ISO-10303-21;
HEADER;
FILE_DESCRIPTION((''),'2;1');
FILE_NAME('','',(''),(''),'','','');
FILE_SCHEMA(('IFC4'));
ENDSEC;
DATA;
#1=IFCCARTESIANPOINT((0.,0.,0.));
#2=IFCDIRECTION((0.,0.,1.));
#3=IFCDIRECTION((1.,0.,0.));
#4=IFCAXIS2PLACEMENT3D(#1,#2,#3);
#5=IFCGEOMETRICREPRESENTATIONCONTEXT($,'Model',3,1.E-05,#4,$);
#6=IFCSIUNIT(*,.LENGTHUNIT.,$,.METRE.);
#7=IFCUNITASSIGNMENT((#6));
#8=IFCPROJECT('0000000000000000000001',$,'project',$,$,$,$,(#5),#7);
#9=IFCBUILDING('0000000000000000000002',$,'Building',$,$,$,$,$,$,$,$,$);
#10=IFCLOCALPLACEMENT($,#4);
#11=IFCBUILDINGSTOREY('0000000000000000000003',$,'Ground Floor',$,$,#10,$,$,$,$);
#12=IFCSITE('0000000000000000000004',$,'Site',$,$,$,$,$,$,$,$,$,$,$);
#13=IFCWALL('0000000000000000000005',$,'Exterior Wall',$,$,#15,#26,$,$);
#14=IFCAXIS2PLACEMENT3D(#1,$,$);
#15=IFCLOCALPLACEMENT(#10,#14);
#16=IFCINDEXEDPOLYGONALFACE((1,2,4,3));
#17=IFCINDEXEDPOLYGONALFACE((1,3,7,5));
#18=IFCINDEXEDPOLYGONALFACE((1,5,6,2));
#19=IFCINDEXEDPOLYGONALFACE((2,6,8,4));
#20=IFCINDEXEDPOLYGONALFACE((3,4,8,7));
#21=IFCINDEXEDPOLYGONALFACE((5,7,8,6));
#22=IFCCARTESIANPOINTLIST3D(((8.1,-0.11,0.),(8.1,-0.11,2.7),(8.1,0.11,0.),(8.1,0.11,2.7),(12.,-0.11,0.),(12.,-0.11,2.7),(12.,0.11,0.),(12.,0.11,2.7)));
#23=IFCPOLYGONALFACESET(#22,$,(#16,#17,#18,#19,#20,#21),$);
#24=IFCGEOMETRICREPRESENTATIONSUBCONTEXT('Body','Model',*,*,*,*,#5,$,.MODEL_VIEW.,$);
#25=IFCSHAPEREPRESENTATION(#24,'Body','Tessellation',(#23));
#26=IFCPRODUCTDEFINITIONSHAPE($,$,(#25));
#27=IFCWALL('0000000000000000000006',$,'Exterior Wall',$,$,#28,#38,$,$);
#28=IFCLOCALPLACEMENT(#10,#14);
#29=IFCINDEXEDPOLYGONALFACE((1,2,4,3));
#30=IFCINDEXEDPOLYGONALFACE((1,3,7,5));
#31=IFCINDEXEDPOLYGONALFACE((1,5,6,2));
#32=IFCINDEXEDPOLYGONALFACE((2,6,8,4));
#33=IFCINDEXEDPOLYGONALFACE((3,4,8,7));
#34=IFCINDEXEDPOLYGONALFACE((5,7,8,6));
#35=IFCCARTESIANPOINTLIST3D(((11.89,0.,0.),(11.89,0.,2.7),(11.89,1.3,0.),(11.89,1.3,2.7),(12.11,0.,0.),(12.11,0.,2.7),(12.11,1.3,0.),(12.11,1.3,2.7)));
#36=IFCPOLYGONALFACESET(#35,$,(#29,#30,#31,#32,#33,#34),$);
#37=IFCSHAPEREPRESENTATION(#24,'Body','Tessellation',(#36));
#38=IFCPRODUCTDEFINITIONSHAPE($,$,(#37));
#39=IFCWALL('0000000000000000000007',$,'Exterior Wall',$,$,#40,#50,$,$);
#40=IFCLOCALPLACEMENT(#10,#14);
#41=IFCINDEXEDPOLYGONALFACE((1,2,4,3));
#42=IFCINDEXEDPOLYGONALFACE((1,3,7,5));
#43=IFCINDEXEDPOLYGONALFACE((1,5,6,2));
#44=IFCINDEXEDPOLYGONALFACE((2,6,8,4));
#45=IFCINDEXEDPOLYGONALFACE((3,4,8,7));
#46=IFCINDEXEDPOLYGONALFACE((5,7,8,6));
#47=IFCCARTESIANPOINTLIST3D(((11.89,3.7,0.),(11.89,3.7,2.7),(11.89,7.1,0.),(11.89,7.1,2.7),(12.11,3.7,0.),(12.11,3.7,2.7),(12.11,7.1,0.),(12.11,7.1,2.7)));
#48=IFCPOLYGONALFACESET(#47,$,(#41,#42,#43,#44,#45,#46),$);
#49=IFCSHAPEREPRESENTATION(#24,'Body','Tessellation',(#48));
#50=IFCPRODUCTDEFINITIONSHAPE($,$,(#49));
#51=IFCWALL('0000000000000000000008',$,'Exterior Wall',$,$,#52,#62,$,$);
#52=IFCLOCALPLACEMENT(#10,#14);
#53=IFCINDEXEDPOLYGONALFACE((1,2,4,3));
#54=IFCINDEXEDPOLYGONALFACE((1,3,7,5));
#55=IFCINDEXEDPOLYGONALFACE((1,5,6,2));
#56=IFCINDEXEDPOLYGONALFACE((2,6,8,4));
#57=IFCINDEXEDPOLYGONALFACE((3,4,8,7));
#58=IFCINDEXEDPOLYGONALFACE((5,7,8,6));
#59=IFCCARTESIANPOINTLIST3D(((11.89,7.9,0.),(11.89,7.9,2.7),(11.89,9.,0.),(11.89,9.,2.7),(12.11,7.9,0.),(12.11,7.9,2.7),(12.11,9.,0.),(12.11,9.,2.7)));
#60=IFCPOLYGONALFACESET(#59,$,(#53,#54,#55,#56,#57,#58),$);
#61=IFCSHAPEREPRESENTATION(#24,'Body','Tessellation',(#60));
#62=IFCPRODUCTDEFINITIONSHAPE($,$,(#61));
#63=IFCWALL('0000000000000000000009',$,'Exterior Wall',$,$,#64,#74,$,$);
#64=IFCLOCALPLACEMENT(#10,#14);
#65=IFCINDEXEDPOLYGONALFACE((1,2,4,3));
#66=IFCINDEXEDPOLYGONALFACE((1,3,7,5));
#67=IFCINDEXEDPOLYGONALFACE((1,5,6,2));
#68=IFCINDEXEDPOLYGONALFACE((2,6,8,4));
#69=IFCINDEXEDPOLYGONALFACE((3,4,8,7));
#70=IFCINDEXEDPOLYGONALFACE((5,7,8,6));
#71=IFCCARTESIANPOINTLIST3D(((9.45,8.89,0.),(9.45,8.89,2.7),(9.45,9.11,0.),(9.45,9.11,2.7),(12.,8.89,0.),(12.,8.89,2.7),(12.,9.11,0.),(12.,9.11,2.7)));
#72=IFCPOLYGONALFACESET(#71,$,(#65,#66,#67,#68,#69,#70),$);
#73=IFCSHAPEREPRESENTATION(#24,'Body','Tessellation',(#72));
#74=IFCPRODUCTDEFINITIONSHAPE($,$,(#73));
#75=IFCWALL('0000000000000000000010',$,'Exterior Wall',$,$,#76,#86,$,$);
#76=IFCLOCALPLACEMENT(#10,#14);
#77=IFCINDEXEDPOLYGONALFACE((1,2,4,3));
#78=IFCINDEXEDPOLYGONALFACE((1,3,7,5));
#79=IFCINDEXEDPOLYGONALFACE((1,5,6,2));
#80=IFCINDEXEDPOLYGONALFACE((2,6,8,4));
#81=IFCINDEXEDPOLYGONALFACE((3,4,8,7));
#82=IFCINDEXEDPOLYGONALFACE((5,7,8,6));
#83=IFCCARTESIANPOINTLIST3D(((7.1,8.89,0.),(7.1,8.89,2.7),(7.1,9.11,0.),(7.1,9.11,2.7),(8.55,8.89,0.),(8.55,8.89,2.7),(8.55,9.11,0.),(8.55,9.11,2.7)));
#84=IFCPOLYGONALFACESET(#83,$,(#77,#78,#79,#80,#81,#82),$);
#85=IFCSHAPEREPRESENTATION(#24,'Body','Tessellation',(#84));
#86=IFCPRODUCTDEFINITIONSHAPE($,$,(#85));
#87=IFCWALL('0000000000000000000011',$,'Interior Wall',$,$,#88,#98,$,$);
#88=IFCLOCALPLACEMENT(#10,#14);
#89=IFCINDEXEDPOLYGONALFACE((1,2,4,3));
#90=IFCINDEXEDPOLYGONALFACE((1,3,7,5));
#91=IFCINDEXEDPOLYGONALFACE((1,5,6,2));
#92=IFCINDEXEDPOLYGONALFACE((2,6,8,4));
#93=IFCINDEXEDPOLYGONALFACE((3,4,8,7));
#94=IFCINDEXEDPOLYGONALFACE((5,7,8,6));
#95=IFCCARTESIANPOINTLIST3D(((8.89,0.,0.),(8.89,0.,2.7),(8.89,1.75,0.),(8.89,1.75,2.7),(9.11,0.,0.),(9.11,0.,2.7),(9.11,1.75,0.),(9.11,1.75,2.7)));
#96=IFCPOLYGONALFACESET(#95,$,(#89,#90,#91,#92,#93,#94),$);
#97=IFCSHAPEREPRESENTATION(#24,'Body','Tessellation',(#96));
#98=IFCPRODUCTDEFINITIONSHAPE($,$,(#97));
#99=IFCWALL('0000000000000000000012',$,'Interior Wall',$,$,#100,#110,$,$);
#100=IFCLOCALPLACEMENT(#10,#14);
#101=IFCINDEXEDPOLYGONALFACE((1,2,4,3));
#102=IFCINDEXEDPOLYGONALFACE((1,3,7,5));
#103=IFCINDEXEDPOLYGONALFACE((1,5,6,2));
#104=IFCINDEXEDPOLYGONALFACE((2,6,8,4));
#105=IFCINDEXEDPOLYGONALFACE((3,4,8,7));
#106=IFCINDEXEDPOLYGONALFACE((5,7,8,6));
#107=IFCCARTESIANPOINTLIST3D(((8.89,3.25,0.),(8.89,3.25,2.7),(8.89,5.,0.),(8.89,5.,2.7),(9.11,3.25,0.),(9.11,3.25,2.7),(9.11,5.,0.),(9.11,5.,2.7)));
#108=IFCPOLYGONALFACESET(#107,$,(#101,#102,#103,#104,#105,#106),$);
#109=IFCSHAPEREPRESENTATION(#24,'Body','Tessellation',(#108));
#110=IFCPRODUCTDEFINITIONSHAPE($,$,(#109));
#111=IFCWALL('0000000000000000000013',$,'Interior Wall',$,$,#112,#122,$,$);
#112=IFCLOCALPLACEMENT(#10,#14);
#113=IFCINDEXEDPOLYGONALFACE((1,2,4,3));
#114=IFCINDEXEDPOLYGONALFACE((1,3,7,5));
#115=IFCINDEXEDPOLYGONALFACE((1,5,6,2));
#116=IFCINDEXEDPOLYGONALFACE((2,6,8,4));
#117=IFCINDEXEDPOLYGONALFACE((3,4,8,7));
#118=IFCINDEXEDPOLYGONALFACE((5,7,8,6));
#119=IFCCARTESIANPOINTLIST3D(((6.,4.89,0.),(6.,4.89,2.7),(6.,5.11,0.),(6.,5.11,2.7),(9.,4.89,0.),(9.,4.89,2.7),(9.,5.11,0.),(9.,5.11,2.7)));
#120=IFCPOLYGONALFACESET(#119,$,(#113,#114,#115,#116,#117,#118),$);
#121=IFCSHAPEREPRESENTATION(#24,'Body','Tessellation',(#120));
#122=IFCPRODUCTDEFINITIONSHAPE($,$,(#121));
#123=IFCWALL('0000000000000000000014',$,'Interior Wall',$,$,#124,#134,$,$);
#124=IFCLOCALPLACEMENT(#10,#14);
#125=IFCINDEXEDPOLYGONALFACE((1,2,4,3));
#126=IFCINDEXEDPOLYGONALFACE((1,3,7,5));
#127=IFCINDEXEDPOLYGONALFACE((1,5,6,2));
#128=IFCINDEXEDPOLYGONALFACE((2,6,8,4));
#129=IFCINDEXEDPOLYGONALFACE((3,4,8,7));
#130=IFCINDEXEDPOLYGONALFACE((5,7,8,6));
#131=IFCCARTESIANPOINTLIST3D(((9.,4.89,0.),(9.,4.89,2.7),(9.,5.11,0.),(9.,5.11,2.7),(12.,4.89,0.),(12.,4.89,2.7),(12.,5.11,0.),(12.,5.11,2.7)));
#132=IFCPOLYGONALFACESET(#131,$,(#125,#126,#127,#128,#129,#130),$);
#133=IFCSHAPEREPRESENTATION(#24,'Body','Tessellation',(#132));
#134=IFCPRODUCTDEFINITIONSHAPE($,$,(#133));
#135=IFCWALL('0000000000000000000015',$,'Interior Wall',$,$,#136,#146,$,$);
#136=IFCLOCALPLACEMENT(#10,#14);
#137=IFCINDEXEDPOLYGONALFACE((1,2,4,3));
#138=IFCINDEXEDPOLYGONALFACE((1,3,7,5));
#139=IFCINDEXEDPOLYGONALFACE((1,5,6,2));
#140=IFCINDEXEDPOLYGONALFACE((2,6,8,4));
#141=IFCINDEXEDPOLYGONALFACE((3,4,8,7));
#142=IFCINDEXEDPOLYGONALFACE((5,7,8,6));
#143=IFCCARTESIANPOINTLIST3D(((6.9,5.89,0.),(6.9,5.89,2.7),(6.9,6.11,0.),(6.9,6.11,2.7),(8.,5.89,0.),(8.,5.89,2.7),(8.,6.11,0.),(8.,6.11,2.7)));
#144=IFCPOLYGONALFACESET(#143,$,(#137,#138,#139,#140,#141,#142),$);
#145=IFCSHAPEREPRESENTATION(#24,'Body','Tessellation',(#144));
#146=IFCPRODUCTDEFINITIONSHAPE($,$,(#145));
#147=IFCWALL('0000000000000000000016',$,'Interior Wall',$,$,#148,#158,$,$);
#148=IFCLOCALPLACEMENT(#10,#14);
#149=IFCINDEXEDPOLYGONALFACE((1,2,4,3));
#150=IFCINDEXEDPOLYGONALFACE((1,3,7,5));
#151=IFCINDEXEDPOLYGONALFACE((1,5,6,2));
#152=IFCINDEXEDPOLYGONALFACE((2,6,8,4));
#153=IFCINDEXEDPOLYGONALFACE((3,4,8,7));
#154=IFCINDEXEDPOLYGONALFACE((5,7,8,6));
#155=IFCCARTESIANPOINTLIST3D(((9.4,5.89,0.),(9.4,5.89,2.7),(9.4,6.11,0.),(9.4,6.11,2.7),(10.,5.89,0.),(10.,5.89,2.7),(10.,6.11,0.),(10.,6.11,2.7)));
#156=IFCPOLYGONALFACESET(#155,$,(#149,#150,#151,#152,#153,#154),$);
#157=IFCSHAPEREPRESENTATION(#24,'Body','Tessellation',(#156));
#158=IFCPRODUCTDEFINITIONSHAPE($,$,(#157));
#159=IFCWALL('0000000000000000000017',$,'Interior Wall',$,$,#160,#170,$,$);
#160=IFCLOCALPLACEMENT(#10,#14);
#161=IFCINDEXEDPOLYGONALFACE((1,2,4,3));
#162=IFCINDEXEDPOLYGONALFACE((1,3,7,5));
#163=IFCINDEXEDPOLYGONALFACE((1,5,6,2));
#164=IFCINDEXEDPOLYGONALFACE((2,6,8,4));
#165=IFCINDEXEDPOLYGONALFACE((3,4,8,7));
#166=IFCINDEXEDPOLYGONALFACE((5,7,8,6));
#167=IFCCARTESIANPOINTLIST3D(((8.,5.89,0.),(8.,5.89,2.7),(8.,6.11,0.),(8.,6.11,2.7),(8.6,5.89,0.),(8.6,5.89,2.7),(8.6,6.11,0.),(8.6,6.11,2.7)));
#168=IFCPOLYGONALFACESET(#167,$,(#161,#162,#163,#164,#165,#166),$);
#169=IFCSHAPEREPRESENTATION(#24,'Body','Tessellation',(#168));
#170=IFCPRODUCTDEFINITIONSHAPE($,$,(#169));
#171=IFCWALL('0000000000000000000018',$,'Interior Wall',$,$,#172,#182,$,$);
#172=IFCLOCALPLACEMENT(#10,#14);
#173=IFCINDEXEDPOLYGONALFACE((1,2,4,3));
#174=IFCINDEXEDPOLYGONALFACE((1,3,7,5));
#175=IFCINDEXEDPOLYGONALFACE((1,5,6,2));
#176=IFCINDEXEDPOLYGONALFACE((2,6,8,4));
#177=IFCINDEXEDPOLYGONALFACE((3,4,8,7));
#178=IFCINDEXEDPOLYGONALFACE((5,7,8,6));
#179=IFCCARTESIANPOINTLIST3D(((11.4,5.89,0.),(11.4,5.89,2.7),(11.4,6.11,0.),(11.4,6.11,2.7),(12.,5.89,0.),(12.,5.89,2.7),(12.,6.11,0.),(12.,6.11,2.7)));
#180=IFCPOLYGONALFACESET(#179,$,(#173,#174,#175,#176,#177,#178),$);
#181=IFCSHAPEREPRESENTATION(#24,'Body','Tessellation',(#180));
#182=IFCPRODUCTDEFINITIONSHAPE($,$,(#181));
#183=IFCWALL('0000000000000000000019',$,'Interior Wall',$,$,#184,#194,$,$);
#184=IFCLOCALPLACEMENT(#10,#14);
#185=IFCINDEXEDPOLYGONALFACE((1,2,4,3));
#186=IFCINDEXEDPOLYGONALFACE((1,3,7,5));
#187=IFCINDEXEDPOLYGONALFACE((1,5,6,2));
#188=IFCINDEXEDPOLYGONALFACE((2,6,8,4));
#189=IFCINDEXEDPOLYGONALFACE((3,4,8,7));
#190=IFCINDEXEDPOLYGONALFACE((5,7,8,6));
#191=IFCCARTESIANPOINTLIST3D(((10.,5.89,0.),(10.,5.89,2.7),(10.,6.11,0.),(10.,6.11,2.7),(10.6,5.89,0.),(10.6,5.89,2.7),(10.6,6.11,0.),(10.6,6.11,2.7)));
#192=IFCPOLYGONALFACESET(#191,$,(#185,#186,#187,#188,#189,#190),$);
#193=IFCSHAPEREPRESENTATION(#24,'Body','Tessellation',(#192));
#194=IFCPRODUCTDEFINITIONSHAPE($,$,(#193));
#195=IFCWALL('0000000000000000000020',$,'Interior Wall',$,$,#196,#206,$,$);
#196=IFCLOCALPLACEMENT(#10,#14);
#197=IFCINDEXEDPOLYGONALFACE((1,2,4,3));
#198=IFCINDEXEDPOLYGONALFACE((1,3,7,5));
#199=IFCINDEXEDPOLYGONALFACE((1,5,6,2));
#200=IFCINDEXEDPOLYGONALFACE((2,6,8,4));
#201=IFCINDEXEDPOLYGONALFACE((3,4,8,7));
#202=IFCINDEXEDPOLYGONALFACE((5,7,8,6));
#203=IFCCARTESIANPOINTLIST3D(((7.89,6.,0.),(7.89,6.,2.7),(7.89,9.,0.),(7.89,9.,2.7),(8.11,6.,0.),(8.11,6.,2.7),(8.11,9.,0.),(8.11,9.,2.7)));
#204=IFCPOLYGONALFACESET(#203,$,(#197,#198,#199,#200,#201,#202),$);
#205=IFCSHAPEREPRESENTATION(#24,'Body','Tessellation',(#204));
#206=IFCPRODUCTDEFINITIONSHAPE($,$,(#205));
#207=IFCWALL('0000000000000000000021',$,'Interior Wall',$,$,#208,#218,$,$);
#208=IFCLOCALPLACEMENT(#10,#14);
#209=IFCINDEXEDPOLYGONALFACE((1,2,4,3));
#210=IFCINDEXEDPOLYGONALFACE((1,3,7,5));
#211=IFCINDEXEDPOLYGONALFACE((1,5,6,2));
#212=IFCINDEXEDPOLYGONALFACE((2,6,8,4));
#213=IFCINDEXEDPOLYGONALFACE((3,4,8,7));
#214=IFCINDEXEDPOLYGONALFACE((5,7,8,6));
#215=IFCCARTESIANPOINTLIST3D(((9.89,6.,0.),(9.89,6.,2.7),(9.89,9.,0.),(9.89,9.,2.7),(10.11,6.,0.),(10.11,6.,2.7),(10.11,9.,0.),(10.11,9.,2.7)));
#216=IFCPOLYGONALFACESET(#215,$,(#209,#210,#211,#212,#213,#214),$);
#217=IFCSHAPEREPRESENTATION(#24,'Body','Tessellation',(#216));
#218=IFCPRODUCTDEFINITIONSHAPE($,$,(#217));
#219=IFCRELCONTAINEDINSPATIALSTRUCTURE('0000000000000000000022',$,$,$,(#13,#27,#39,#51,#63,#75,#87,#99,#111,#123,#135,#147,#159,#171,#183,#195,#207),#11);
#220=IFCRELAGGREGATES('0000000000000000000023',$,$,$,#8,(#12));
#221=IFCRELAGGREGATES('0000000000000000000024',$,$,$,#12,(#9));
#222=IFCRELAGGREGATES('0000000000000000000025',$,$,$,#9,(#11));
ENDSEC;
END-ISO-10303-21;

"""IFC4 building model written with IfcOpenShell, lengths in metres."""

from ifc_helpers import new_model, si_unit, frame, origin_with_axes, place, context, subcontext, project, spatial, indexed_curve, outline, extrude, element, save


model = new_model("IFC4")

# Units and contexts
model_context = context("Model", 3, precision=1e-05, world=origin_with_axes())
body_context = subcontext(model_context, "Body", "Model", "MODEL_VIEW")
ifc_project = project(units=[si_unit("LENGTHUNIT", "METRE")], contexts=[model_context])

# Site, building, storey
site = spatial("IfcSite", under=ifc_project, Name="Site")
building = spatial("IfcBuilding", under=site, Name="Building")
storey_placement = place(None, origin_with_axes())
storey = spatial("IfcBuildingStorey", under=building, at=storey_placement, Name="Ground Floor")

# Walls
wall_1_placement = place(storey_placement, frame((8.1, 0.0, 0.0), z_axis=(0.0, 0.0, 1.0), x_axis=(1.0, 0.0, 0.0)))
element("IfcWall", 1, at=wall_1_placement, inside=storey, Name="Exterior Wall", context=body_context, shape_type="SweptSolid", body=[
    extrude(outline(indexed_curve([(0.0, 0.0), (0.0, 0.22), (3.9, 0.22), (3.9, 0.0), (0.0, 0.0)], self_intersect=False)), frame((0.0, -0.11, 0.0), z_axis=(0.0, 0.0, 1.0), x_axis=(1.0, 0.0, 0.0)), (0.0, 0.0, 1.0), 2.7),
])
wall_2_placement = place(storey_placement, frame((12.0, 0.0, 0.0), z_axis=(0.0, 0.0, 1.0), x_axis=(0.0, 1.0, 0.0)))
element("IfcWall", 2, at=wall_2_placement, inside=storey, Name="Exterior Wall", context=body_context, shape_type="SweptSolid", body=[
    extrude(outline(indexed_curve([(0.0, 0.0), (0.0, 0.22), (1.3, 0.22), (1.3, 0.0), (0.0, 0.0)], self_intersect=False)), frame((0.0, -0.11, 0.0), z_axis=(0.0, 0.0, 1.0), x_axis=(1.0, 0.0, 0.0)), (0.0, 0.0, 1.0), 2.7),
])
wall_3_placement = place(storey_placement, frame((12.0, 3.7, 0.0), z_axis=(0.0, 0.0, 1.0), x_axis=(0.0, 1.0, 0.0)))
element("IfcWall", 3, at=wall_3_placement, inside=storey, Name="Exterior Wall", context=body_context, shape_type="SweptSolid", body=[
    extrude(outline(indexed_curve([(0.0, 0.0), (0.0, 0.22), (3.4, 0.22), (3.4, 0.0), (0.0, 0.0)], self_intersect=False)), frame((0.0, -0.11, 0.0), z_axis=(0.0, 0.0, 1.0), x_axis=(1.0, 0.0, 0.0)), (0.0, 0.0, 1.0), 2.7),
])
wall_4_placement = place(storey_placement, frame((12.0, 7.9, 0.0), z_axis=(0.0, 0.0, 1.0), x_axis=(0.0, 1.0, 0.0)))
element("IfcWall", 4, at=wall_4_placement, inside=storey, Name="Exterior Wall", context=body_context, shape_type="SweptSolid", body=[
    extrude(outline(indexed_curve([(0.0, 0.0), (0.0, 0.22), (1.1, 0.22), (1.1, 0.0), (0.0, 0.0)], self_intersect=False)), frame((0.0, -0.11, 0.0), z_axis=(0.0, 0.0, 1.0), x_axis=(1.0, 0.0, 0.0)), (0.0, 0.0, 1.0), 2.7),
])
wall_5_placement = place(storey_placement, frame((12.0, 9.0, 0.0), z_axis=(0.0, 0.0, 1.0), x_axis=(-1.0, 0.0, 0.0)))
element("IfcWall", 5, at=wall_5_placement, inside=storey, Name="Exterior Wall", context=body_context, shape_type="SweptSolid", body=[
    extrude(outline(indexed_curve([(0.0, 0.0), (0.0, 0.22), (2.55, 0.22), (2.55, 0.0), (0.0, 0.0)], self_intersect=False)), frame((0.0, -0.11, 0.0), z_axis=(0.0, 0.0, 1.0), x_axis=(1.0, 0.0, 0.0)), (0.0, 0.0, 1.0), 2.7),
])
wall_6_placement = place(storey_placement, frame((8.55, 9.0, 0.0), z_axis=(0.0, 0.0, 1.0), x_axis=(-1.0, 0.0, 0.0)))
element("IfcWall", 6, at=wall_6_placement, inside=storey, Name="Exterior Wall", context=body_context, shape_type="SweptSolid", body=[
    extrude(outline(indexed_curve([(0.0, 0.0), (0.0, 0.22), (1.45, 0.22), (1.45, 0.0), (0.0, 0.0)], self_intersect=False)), frame((0.0, -0.11, 0.0), z_axis=(0.0, 0.0, 1.0), x_axis=(1.0, 0.0, 0.0)), (0.0, 0.0, 1.0), 2.7),
])
for number, where, z_axis, x_axis, name in (
    (7, (9.0, 0.0, 0.0), (0.0, 0.0, 1.0), (0.0, 1.0, 0.0), "Interior Wall"),
    (8, (9.0, 3.25, 0.0), (0.0, 0.0, 1.0), (0.0, 1.0, 0.0), "Interior Wall"),
):
    element("IfcWall", number, at=place(storey_placement, frame(where, z_axis=z_axis, x_axis=x_axis)), inside=storey, Name=name, context=body_context, shape_type="SweptSolid", body=[
        extrude(outline(indexed_curve([(0.0, 0.0), (0.0, 0.22), (1.75, 0.22), (1.75, 0.0), (0.0, 0.0)], self_intersect=False)), frame((0.0, -0.11, 0.0), z_axis=(0.0, 0.0, 1.0), x_axis=(1.0, 0.0, 0.0)), (0.0, 0.0, 1.0), 2.7),
    ])
for number, where, z_axis, x_axis, name in (
    (9, (9.0, 5.0, 0.0), (0.0, 0.0, 1.0), (-1.0, 0.0, 0.0), "Interior Wall"),
    (10, (12.0, 5.0, 0.0), (0.0, 0.0, 1.0), (-1.0, 0.0, 0.0), "Interior Wall"),
):
    element("IfcWall", number, at=place(storey_placement, frame(where, z_axis=z_axis, x_axis=x_axis)), inside=storey, Name=name, context=body_context, shape_type="SweptSolid", body=[
        extrude(outline(indexed_curve([(0.0, 0.0), (0.0, 0.22), (3.0, 0.22), (3.0, 0.0), (0.0, 0.0)], self_intersect=False)), frame((0.0, -0.11, 0.0), z_axis=(0.0, 0.0, 1.0), x_axis=(1.0, 0.0, 0.0)), (0.0, 0.0, 1.0), 2.7),
    ])
wall_7_placement = place(storey_placement, frame((8.0, 6.0, 0.0), z_axis=(0.0, 0.0, 1.0), x_axis=(-1.0, 0.0, 0.0)))
element("IfcWall", 11, at=wall_7_placement, inside=storey, Name="Interior Wall", context=body_context, shape_type="SweptSolid", body=[
    extrude(outline(indexed_curve([(0.0, 0.0), (0.0, 0.22), (1.1, 0.22), (1.1, 0.0), (0.0, 0.0)], self_intersect=False)), frame((0.0, -0.11, 0.0), z_axis=(0.0, 0.0, 1.0), x_axis=(1.0, 0.0, 0.0)), (0.0, 0.0, 1.0), 2.7),
])
for number, where, z_axis, x_axis, name in (
    (12, (10.0, 6.0, 0.0), (0.0, 0.0, 1.0), (-1.0, 0.0, 0.0), "Interior Wall"),
    (13, (8.6, 6.0, 0.0), (0.0, 0.0, 1.0), (-1.0, 0.0, 0.0), "Interior Wall"),
    (14, (12.0, 6.0, 0.0), (0.0, 0.0, 1.0), (-1.0, 0.0, 0.0), "Interior Wall"),
    (15, (10.6, 6.0, 0.0), (0.0, 0.0, 1.0), (-1.0, 0.0, 0.0), "Interior Wall"),
):
    element("IfcWall", number, at=place(storey_placement, frame(where, z_axis=z_axis, x_axis=x_axis)), inside=storey, Name=name, context=body_context, shape_type="SweptSolid", body=[
        extrude(outline(indexed_curve([(0.0, 0.0), (0.0, 0.22), (0.6, 0.22), (0.6, 0.0), (0.0, 0.0)], self_intersect=False)), frame((0.0, -0.11, 0.0), z_axis=(0.0, 0.0, 1.0), x_axis=(1.0, 0.0, 0.0)), (0.0, 0.0, 1.0), 2.7),
    ])
for number, where, z_axis, x_axis, name in (
    (16, (8.0, 6.0, 0.0), (0.0, 0.0, 1.0), (0.0, 1.0, 0.0), "Interior Wall"),
    (17, (10.0, 6.0, 0.0), (0.0, 0.0, 1.0), (0.0, 1.0, 0.0), "Interior Wall"),
):
    element("IfcWall", number, at=place(storey_placement, frame(where, z_axis=z_axis, x_axis=x_axis)), inside=storey, Name=name, context=body_context, shape_type="SweptSolid", body=[
        extrude(outline(indexed_curve([(0.0, 0.0), (0.0, 0.22), (3.0, 0.22), (3.0, 0.0), (0.0, 0.0)], self_intersect=False)), frame((0.0, -0.11, 0.0), z_axis=(0.0, 0.0, 1.0), x_axis=(1.0, 0.0, 0.0)), (0.0, 0.0, 1.0), 2.7),
    ])

save(model, "model.ifc")
